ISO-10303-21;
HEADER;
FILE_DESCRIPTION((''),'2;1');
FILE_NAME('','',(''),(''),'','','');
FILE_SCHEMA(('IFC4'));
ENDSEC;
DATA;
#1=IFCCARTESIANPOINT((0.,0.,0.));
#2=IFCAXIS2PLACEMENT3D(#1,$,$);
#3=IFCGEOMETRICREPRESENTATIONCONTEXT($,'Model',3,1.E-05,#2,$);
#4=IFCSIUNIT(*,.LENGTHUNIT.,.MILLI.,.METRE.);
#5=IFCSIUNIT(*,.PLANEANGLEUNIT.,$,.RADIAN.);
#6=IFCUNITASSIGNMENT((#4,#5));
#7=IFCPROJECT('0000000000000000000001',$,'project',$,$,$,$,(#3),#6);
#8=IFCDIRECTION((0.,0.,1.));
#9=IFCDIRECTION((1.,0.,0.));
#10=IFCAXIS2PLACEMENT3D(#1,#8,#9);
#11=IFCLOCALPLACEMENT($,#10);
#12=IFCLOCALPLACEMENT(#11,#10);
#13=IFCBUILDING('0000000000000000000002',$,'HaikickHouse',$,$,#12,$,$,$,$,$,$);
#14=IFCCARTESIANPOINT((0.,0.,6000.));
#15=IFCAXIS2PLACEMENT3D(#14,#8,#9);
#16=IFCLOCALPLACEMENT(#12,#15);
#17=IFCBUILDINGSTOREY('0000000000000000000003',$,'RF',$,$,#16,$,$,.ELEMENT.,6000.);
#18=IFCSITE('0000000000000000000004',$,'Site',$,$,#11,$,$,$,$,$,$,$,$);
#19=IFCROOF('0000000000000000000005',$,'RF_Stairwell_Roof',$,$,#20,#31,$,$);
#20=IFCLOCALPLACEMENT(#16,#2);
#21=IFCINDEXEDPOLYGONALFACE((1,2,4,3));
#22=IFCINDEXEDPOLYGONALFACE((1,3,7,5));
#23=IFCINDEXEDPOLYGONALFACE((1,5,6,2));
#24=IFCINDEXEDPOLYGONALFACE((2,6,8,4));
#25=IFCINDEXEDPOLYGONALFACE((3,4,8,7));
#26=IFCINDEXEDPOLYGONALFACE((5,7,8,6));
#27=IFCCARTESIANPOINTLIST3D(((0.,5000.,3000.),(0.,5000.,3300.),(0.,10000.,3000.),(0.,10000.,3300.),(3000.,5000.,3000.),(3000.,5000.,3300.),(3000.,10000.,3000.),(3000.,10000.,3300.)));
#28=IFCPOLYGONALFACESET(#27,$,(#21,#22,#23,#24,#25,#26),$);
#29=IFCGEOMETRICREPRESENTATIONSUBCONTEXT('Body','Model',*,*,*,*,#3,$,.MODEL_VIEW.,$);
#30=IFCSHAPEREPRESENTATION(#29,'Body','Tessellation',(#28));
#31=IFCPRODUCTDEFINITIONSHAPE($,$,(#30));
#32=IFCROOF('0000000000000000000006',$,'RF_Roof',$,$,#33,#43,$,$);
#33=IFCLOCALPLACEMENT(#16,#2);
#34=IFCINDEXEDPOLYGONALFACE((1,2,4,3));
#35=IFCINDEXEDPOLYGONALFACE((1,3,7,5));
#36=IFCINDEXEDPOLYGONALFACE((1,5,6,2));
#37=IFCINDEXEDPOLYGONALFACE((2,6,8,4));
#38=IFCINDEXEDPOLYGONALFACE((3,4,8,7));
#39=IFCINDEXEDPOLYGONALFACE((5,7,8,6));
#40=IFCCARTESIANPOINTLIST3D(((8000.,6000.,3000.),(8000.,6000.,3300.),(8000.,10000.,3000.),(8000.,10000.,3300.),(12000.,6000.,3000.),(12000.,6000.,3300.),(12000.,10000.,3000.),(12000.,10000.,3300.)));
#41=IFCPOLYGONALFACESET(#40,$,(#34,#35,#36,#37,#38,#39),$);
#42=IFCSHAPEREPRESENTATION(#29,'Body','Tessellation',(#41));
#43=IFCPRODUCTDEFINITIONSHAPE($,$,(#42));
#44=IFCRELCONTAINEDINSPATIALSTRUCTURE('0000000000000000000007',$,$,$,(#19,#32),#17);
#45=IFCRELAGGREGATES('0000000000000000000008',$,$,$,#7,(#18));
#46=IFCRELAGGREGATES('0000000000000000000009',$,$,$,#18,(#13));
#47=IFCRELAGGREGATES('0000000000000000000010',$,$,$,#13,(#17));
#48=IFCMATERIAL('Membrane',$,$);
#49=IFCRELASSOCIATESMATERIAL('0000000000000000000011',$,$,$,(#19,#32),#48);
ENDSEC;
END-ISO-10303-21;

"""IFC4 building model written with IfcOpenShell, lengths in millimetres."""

from ifc_helpers import new_model, si_unit, frame, origin, origin_with_axes, place, context, subcontext, project, spatial, rectangle, extrude, material, element, save


model = new_model("IFC4")

# Units and contexts
model_context = context("Model", 3, precision=1e-05, world=origin())
body_context = subcontext(model_context, "Body", "Model", "MODEL_VIEW")
ifc_project = project(units=[si_unit("LENGTHUNIT", "METRE", prefix="MILLI"), si_unit("PLANEANGLEUNIT", "RADIAN")], contexts=[model_context])

# Site, building, storey
site_placement = place(None, origin_with_axes())
site = spatial("IfcSite", under=ifc_project, at=site_placement, Name="Site")
building_placement = place(site_placement, origin_with_axes())
building = spatial("IfcBuilding", under=site, at=building_placement, Name="HaikickHouse")
storey_placement = place(building_placement, frame((0.0, 0.0, 6000.0), z_axis=(0.0, 0.0, 1.0), x_axis=(1.0, 0.0, 0.0)))
storey = spatial("IfcBuildingStorey", under=building, at=storey_placement, Name="RF", CompositionType="ELEMENT", Elevation=6000.0)

# Roofs
ifc_material_1 = material(Name="Membrane")
roof_1_placement = place(None, frame((0.0, 5000.0, 9000.0), z_axis=(0.0, 0.0, 1.0), x_axis=(1.0, 0.0, 0.0)))
element("IfcRoof", 1, at=roof_1_placement, inside=storey, material=ifc_material_1, Name="RF_Stairwell_Roof", context=body_context, shape_type="SweptSolid", body=[
    extrude(rectangle(XDim=3000.0, YDim=5000.0), frame((1500.0, 2500.0, 0.0)), (0.0, 0.0, 1.0), 300.0),
])
roof_2_placement = place(None, frame((8000.0, 6000.0, 9000.0), z_axis=(0.0, 0.0, 1.0), x_axis=(1.0, 0.0, 0.0)))
element("IfcRoof", 2, at=roof_2_placement, inside=storey, material=ifc_material_1, Name="RF_Roof", context=body_context, shape_type="SweptSolid", body=[
    extrude(rectangle(XDim=4000.0, YDim=4000.0), frame((2000.0, 2000.0, 0.0)), (0.0, 0.0, 1.0), 300.0),
])

save(model, "model.ifc")
